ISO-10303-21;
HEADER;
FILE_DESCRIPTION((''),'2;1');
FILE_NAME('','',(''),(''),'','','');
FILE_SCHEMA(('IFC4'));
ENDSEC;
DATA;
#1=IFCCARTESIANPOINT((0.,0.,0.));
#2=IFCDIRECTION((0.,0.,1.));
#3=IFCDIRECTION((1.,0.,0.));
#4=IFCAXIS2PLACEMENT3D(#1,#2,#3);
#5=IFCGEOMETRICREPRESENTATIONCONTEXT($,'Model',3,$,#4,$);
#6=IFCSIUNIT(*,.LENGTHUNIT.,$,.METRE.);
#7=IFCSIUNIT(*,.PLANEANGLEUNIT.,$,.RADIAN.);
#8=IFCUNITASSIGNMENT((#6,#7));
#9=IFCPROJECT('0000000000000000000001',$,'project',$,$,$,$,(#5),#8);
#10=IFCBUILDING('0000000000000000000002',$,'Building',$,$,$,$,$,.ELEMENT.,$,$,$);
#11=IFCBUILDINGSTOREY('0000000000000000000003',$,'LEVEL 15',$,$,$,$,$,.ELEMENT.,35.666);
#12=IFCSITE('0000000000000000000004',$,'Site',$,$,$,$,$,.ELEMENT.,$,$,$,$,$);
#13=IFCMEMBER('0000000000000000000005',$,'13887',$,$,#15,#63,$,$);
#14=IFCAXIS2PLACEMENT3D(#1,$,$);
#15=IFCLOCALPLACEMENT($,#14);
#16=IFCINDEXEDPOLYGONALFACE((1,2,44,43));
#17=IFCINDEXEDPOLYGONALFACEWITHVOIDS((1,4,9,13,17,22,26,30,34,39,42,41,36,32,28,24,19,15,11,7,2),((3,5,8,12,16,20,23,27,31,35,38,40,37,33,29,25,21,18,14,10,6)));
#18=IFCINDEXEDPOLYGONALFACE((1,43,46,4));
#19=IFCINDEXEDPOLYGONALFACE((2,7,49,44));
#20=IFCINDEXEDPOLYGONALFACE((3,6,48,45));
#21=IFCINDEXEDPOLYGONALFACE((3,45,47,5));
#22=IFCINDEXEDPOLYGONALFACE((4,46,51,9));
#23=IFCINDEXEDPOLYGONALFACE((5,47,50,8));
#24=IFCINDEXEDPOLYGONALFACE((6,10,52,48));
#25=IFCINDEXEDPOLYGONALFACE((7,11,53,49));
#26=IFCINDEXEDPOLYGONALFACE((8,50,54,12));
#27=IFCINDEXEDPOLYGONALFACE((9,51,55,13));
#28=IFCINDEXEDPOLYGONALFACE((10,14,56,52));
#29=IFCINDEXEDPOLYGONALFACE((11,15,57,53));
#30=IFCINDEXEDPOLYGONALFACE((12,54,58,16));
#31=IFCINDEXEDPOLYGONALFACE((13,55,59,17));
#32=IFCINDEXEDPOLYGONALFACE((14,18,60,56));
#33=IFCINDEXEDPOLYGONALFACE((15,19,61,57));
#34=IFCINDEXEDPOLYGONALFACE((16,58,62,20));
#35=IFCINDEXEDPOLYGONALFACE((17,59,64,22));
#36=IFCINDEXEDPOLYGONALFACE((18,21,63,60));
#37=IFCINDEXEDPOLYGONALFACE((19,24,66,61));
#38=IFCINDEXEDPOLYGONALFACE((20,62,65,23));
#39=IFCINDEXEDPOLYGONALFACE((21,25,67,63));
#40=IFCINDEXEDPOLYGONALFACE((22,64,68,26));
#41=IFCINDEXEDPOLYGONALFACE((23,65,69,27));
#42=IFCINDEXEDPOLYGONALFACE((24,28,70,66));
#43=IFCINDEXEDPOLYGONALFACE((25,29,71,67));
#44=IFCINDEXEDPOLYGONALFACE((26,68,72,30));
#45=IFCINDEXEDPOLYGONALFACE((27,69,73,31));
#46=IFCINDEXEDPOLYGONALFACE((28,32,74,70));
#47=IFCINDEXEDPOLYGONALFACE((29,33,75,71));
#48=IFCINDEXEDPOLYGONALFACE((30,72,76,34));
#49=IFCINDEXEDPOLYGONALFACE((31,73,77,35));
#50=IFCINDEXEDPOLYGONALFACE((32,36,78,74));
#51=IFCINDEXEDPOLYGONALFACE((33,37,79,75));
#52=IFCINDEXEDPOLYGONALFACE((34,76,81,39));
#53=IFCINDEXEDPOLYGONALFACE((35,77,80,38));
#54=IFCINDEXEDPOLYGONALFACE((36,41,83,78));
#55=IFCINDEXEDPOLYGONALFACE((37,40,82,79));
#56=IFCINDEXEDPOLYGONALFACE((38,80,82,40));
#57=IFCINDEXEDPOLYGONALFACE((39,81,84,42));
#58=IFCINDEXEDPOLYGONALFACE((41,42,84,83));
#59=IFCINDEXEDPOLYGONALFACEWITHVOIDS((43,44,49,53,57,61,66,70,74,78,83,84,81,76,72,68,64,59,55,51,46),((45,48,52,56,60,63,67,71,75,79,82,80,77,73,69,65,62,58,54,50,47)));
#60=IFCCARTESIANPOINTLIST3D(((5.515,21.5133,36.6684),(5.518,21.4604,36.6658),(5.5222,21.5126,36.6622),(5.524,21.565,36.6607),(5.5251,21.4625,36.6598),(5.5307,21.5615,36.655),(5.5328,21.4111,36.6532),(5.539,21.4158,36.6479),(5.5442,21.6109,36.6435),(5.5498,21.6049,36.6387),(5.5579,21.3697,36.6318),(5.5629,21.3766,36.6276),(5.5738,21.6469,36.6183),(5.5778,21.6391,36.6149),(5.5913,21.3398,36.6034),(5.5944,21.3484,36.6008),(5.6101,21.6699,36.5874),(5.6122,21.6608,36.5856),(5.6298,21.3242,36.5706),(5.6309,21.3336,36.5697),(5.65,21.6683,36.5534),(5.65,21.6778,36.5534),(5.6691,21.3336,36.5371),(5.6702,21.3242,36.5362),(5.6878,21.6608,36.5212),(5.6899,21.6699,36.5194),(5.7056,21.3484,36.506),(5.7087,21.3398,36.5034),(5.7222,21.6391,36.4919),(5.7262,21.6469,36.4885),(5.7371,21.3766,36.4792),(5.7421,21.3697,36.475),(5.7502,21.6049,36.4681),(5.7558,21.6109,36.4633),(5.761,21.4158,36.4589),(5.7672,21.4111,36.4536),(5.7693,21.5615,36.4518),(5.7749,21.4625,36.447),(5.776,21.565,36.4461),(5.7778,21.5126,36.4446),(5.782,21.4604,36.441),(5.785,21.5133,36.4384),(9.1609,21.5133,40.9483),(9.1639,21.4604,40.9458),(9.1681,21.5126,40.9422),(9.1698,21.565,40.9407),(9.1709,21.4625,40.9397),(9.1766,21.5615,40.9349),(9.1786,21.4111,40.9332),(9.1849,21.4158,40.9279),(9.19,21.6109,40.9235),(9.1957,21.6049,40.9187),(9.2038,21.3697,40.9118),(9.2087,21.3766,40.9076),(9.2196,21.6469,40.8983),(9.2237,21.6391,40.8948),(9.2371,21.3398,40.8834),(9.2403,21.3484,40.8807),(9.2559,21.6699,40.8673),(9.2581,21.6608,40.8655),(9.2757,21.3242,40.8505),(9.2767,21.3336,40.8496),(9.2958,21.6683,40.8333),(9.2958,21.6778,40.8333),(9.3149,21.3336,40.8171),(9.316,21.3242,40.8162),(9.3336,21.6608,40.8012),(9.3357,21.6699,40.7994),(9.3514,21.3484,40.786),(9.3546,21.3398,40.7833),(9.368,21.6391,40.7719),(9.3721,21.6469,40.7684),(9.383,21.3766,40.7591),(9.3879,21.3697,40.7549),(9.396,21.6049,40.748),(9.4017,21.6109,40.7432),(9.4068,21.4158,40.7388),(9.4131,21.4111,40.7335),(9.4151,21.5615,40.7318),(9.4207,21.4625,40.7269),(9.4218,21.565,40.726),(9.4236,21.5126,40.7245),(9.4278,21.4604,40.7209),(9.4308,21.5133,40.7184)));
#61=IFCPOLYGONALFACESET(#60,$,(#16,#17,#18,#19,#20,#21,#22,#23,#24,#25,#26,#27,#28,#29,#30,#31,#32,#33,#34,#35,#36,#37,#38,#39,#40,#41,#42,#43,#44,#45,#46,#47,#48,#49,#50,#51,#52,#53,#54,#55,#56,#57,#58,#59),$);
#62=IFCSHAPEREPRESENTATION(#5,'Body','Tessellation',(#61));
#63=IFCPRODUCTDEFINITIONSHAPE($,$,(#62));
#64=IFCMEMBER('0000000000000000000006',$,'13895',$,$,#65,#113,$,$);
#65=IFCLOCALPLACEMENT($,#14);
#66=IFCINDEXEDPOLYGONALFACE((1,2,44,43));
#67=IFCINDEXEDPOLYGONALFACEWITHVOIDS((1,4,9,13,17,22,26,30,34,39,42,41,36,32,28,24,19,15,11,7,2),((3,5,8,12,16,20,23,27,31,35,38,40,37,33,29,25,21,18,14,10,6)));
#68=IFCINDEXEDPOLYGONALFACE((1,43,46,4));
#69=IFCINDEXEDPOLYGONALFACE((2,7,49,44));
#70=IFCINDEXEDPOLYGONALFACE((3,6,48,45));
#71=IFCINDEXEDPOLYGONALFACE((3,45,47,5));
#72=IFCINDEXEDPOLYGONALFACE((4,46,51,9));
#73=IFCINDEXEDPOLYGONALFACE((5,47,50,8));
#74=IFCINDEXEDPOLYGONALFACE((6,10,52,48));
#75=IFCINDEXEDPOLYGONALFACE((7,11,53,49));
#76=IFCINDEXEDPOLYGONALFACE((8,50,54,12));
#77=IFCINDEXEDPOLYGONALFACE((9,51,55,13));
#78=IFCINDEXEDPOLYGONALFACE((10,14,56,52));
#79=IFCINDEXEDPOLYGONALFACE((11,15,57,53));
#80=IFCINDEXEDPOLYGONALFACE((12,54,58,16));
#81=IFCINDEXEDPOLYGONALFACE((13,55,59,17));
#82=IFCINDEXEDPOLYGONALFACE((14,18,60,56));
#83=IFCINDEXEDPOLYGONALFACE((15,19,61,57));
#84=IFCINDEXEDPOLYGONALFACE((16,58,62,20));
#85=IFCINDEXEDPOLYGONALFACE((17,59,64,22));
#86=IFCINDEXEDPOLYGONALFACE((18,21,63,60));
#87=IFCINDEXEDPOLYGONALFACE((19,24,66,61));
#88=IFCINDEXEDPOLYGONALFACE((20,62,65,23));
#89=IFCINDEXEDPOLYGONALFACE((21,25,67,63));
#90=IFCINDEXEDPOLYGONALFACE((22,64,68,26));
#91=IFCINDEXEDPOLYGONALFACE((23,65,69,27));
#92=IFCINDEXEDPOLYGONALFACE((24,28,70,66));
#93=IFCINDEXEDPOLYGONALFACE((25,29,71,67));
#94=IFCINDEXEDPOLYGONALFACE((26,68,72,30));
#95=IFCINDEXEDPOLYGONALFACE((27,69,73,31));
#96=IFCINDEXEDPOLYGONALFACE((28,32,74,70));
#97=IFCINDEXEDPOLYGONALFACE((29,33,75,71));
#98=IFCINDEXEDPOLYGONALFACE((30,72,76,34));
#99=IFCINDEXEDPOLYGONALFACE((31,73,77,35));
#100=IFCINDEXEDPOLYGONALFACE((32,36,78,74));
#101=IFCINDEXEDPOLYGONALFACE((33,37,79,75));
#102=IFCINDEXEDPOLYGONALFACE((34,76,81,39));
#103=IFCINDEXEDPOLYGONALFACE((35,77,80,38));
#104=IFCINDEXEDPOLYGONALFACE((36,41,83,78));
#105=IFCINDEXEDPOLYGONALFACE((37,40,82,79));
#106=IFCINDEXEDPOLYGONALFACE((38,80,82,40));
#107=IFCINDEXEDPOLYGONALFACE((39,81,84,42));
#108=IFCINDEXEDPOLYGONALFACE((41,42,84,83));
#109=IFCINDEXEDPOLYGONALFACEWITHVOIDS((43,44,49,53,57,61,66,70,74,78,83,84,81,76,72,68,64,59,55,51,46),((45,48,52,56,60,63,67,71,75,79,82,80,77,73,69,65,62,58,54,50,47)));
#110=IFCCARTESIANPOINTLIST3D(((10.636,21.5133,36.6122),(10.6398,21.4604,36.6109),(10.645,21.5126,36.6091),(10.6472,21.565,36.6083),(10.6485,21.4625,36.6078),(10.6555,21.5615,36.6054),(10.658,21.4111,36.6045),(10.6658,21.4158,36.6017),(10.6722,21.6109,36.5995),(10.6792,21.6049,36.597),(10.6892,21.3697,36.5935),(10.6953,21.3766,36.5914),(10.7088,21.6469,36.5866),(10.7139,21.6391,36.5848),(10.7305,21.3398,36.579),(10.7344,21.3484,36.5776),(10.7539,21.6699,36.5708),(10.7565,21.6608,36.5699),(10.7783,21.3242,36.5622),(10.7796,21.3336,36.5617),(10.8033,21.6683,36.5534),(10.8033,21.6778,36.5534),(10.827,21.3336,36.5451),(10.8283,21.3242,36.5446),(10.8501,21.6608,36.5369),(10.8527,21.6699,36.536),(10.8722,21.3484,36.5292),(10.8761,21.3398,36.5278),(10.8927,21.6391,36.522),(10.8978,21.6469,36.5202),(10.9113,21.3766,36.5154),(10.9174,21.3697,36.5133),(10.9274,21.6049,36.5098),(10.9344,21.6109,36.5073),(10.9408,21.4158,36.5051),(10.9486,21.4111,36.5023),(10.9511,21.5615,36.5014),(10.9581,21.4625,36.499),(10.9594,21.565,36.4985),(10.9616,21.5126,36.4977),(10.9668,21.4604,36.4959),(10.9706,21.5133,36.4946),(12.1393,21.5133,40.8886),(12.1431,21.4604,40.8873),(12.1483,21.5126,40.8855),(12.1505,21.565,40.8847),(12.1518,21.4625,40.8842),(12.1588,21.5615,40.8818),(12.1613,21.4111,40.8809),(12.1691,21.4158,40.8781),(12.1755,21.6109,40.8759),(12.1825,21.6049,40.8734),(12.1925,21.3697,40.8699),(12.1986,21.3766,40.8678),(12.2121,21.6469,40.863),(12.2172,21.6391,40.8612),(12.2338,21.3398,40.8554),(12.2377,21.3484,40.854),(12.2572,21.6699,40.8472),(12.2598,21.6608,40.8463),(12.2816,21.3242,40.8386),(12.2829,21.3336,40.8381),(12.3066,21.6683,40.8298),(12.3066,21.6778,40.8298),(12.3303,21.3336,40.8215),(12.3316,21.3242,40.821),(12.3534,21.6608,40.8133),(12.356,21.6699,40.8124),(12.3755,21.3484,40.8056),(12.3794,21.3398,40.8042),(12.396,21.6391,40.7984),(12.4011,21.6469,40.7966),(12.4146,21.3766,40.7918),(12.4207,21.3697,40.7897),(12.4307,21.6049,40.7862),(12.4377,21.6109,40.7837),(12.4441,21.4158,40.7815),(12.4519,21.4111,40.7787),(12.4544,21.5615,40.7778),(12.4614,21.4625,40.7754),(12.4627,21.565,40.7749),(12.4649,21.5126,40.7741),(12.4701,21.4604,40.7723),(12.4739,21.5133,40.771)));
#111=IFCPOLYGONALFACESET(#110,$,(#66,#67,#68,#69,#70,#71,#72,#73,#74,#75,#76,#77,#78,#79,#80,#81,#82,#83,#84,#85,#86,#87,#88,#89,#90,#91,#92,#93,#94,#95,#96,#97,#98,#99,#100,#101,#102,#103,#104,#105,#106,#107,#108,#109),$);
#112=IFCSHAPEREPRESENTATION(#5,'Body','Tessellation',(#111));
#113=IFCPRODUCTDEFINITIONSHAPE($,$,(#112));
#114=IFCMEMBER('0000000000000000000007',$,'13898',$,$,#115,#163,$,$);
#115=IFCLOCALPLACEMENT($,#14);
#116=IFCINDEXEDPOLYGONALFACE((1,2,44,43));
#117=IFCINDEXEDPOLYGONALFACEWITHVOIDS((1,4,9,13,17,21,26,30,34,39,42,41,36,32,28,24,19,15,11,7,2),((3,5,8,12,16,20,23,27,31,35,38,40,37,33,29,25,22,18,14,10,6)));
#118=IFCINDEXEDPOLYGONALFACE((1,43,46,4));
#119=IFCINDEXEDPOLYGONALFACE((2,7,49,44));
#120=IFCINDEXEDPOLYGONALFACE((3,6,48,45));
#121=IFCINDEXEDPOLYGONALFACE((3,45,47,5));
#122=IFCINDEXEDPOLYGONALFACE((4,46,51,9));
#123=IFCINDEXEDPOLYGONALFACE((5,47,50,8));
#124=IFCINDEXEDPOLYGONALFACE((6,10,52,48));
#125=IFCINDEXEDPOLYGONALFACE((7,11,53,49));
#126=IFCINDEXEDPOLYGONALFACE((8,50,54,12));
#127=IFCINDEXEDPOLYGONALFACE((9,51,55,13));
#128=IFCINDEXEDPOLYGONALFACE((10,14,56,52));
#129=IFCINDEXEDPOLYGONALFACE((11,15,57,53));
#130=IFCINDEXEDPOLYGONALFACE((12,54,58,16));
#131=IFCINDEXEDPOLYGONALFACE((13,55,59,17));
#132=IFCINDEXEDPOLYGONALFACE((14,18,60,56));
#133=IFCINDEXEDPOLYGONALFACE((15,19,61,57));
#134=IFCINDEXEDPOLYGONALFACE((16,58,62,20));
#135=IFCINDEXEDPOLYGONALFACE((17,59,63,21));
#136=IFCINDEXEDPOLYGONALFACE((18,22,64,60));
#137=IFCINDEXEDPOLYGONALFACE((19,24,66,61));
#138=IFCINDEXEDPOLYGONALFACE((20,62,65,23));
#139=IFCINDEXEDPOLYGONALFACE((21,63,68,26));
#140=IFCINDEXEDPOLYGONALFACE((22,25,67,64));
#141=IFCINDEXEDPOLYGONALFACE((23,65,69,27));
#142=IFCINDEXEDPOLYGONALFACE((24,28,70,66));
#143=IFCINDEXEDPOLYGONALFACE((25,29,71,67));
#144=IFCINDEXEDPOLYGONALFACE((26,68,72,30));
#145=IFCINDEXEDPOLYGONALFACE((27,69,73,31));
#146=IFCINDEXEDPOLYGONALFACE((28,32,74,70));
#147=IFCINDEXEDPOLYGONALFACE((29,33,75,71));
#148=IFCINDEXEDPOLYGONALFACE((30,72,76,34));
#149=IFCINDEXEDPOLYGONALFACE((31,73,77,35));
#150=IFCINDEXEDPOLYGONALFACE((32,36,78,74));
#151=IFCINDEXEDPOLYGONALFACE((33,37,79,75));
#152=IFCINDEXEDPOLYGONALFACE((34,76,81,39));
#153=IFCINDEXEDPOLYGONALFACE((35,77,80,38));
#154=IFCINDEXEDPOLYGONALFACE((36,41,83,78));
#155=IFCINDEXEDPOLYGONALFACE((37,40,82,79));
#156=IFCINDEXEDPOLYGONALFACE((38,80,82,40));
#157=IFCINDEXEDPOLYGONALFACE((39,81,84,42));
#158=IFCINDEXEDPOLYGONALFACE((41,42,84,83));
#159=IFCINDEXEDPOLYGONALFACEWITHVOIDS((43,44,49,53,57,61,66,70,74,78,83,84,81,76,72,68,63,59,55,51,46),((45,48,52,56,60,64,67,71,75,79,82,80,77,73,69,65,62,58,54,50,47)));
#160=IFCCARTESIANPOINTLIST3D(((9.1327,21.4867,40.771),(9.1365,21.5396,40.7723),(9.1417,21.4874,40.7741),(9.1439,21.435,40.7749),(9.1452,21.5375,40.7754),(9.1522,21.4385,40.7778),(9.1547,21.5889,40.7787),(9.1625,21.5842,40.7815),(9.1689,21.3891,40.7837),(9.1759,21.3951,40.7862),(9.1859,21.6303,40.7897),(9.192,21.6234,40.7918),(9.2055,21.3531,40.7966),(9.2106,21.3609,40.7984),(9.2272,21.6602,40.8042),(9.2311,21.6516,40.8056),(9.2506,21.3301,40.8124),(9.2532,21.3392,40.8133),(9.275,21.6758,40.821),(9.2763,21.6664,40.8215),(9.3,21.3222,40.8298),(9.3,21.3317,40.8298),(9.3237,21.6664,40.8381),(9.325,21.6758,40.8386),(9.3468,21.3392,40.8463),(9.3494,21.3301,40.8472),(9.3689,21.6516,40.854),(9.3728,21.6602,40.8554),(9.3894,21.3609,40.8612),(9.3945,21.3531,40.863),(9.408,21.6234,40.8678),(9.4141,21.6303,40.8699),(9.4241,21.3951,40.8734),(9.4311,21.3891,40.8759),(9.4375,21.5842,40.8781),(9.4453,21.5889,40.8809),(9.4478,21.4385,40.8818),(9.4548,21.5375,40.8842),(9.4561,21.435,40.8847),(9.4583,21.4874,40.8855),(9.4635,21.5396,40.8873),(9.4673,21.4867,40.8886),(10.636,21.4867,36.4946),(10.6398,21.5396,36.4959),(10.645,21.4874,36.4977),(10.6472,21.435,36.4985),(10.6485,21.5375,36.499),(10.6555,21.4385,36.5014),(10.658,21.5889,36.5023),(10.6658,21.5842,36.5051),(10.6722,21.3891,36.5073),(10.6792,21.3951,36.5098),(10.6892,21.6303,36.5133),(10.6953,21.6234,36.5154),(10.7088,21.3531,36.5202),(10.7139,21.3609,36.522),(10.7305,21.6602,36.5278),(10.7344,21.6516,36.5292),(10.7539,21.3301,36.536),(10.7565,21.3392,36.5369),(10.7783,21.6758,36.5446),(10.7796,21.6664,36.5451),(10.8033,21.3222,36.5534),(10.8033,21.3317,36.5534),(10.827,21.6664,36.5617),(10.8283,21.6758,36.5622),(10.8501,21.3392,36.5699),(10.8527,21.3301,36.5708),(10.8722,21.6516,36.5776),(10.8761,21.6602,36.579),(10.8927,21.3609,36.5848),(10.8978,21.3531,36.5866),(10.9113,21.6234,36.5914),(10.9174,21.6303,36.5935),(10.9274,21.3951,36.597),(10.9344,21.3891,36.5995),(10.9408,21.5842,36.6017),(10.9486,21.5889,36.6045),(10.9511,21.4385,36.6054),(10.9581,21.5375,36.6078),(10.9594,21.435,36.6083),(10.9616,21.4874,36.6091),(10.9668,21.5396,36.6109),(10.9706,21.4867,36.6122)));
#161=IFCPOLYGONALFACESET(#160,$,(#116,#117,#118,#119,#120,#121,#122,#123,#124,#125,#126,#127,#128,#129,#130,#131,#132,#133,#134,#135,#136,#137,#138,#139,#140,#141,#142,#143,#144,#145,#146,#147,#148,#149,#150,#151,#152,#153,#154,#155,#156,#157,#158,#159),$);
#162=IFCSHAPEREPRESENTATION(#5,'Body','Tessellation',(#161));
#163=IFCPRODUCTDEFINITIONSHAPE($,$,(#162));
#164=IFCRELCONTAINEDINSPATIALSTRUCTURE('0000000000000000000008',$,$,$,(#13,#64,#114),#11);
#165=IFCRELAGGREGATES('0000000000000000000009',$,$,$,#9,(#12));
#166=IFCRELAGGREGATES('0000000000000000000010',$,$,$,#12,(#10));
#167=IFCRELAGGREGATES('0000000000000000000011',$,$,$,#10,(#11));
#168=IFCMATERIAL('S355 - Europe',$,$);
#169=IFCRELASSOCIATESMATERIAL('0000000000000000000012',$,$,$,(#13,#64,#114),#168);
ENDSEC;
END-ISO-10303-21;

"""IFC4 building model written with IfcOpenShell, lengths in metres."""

from ifc_helpers import new_model, si_unit, frame, origin_with_axes, origin_2d_with_axis, place, context, project, spatial, hollow_circle, extrude, material, material_profile, profile_set, profile_usage, element, save


model = new_model("IFC4")

# Units and contexts
model_context = context("Model", 3, world=origin_with_axes())
ifc_project = project(units=[si_unit("LENGTHUNIT", "METRE"), si_unit("PLANEANGLEUNIT", "RADIAN")], contexts=[model_context])

# Site, building, storey
site = spatial("IfcSite", under=ifc_project, Name="Site", CompositionType="ELEMENT")
building = spatial("IfcBuilding", under=site, Name="Building", CompositionType="ELEMENT")
storey = spatial("IfcBuildingStorey", under=building, Name="LEVEL 15", CompositionType="ELEMENT", Elevation=35.666)

# Shared definitions
ifc_material = material(Name="S355 - Europe")

# Members
ifc_material_profile_1 = material_profile(ifc_material, hollow_circle(Radius=0.1778, WallThickness=0.0095, at=origin_2d_with_axis()))
ifc_profile_set_1 = profile_set([ifc_material_profile_1])
ifc_profile_usage_1 = profile_usage(ifc_profile_set_1, cardinal=10)
member_1_placement = place(None, frame((5.65, 21.5, 36.5534), z_axis=(0.648463, 0.0, 0.761246), x_axis=(0.0, 1.0, 0.0)))
element("IfcMember", 1, at=member_1_placement, inside=storey, material=ifc_profile_usage_1, Name="13887", context=model_context, shape_type="SweptSolid", body=[
    extrude(hollow_circle(Radius=0.1778, WallThickness=0.0095, at=origin_2d_with_axis()), origin_with_axes(), (0.0, 0.0, 1.0), 5.6223),
])
ifc_material_profile_2 = material_profile(ifc_material, hollow_circle(Radius=0.1778, WallThickness=0.0095, at=origin_2d_with_axis()))
ifc_profile_set_2 = profile_set([ifc_material_profile_2])
ifc_profile_usage_2 = profile_usage(ifc_profile_set_2, cardinal=10)
member_2_placement = place(None, frame((10.8033, 21.5, 36.5534), z_axis=(0.331639, 0.0, 0.943406), x_axis=(0.0, 1.0, 0.0)))
element("IfcMember", 2, at=member_2_placement, inside=storey, material=ifc_profile_usage_2, Name="13895", context=model_context, shape_type="SweptSolid", body=[
    extrude(hollow_circle(Radius=0.1778, WallThickness=0.0095, at=origin_2d_with_axis()), origin_with_axes(), (0.0, 0.0, 1.0), 4.5329),
])
ifc_material_profile_3 = material_profile(ifc_material, hollow_circle(Radius=0.1778, WallThickness=0.0095, at=origin_2d_with_axis()))
ifc_profile_set_3 = profile_set([ifc_material_profile_3])
ifc_profile_usage_3 = profile_usage(ifc_profile_set_3, cardinal=10)
member_3_placement = place(None, frame((10.8033, 21.5, 36.5534), z_axis=(-0.331639, 0.0, 0.943406), x_axis=(0.0, -1.0, 0.0)))
element("IfcMember", 3, at=member_3_placement, inside=storey, material=ifc_profile_usage_3, Name="13898", context=model_context, shape_type="SweptSolid", body=[
    extrude(hollow_circle(Radius=0.1778, WallThickness=0.0095, at=origin_2d_with_axis()), origin_with_axes(), (0.0, 0.0, 1.0), 4.5329),
])

save(model, "model.ifc")
